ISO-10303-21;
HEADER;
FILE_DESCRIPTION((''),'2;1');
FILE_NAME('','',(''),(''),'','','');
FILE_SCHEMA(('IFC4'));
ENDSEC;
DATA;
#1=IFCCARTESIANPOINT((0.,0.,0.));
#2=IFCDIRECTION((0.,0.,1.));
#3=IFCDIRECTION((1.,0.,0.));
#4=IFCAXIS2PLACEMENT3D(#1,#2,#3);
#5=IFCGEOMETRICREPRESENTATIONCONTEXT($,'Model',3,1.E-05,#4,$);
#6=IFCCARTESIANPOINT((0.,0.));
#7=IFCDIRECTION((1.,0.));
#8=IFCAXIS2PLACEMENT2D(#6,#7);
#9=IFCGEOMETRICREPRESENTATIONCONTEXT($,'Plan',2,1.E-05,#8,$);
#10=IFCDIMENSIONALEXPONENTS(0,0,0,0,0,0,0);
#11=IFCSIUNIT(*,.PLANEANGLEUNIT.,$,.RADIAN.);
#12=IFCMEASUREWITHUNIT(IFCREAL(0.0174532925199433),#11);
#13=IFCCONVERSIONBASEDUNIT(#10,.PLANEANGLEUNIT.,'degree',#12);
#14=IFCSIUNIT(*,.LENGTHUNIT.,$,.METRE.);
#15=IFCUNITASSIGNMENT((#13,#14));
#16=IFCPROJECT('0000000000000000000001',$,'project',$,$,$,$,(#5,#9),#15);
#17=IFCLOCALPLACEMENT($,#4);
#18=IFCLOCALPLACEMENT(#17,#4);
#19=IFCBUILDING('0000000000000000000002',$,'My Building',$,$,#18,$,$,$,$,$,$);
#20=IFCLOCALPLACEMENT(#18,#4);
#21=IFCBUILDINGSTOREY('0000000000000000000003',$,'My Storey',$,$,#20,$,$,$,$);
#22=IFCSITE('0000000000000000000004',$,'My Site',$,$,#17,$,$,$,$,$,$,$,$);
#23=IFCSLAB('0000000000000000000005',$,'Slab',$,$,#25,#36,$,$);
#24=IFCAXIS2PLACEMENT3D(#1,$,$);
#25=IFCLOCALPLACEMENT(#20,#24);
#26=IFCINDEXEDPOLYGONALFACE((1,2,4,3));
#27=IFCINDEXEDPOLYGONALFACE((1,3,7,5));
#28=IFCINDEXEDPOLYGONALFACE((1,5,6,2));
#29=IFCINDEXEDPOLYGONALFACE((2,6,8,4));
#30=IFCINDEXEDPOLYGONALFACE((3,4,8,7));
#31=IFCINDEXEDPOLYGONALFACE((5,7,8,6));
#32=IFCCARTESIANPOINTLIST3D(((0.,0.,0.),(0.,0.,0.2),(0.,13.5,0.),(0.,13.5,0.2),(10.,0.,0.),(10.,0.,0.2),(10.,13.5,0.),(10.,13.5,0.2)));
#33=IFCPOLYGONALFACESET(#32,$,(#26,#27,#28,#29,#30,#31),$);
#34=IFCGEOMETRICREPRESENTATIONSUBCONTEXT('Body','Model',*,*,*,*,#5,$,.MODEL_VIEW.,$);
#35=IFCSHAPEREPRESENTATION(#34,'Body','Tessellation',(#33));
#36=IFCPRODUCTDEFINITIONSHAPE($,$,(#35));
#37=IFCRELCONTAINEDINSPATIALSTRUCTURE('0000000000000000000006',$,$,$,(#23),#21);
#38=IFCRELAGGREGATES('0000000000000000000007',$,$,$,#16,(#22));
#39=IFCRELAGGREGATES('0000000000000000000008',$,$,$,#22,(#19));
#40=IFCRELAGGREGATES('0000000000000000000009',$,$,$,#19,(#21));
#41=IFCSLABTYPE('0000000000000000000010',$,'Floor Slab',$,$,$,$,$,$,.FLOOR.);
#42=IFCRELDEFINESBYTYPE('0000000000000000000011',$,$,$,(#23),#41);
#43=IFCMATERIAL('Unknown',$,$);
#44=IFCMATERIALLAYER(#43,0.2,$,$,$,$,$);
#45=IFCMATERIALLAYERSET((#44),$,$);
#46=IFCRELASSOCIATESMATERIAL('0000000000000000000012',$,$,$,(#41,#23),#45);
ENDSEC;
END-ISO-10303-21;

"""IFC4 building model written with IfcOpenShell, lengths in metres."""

from ifc_helpers import new_model, entity, si_unit, converted_unit, origin_with_axes, origin_2d_with_axis, place, context, subcontext, project, spatial, indexed_curve, outline, extrude, material, layer, layer_set, layer_usage, type_object, element, save


model = new_model("IFC4")

# Units and contexts
model_context = context("Model", 3, precision=1e-05, world=origin_with_axes())
plan_context = context("Plan", 2, precision=1e-05, world=origin_2d_with_axis())
body_context = subcontext(model_context, "Body", "Model", "MODEL_VIEW")
ifc_project = project(units=[converted_unit("PLANEANGLEUNIT", "degree", entity("IfcReal", 0.0174532925199433), si_unit("PLANEANGLEUNIT", "RADIAN"), dimensions=[0, 0, 0, 0, 0, 0, 0]), si_unit("LENGTHUNIT", "METRE")], contexts=[model_context, plan_context])

# Site, building, storey
site_placement = place(None, origin_with_axes())
site = spatial("IfcSite", under=ifc_project, at=site_placement, Name="My Site")
building_placement = place(site_placement, origin_with_axes())
building = spatial("IfcBuilding", under=site, at=building_placement, Name="My Building")
storey_placement = place(building_placement, origin_with_axes())
storey = spatial("IfcBuildingStorey", under=building, at=storey_placement, Name="My Storey")

# Slab
ifc_material = material(Name="Unknown")
ifc_layer = layer(ifc_material, 0.2)
ifc_layer_set = layer_set([ifc_layer])
ifc_layer_usage_1 = layer_usage(ifc_layer_set, "AXIS3", "POSITIVE", 0.0)
slab_type = type_object("IfcSlabType", Name="Floor Slab", PredefinedType="FLOOR", material=ifc_layer_set)
slab_1_placement = place(storey_placement, origin_with_axes())
element("IfcSlab", 1, at=slab_1_placement, inside=storey, type_object=slab_type, material=ifc_layer_usage_1, Name="Slab", context=body_context, shape_type="SweptSolid", body=[
    extrude(outline(indexed_curve([(0.0, 0.0), (10.0, 0.0), (10.0, 13.5), (0.0, 13.5), (0.0, 0.0)])), None, (0.0, 0.0, 1.0), 0.2),
])

save(model, "model.ifc")
